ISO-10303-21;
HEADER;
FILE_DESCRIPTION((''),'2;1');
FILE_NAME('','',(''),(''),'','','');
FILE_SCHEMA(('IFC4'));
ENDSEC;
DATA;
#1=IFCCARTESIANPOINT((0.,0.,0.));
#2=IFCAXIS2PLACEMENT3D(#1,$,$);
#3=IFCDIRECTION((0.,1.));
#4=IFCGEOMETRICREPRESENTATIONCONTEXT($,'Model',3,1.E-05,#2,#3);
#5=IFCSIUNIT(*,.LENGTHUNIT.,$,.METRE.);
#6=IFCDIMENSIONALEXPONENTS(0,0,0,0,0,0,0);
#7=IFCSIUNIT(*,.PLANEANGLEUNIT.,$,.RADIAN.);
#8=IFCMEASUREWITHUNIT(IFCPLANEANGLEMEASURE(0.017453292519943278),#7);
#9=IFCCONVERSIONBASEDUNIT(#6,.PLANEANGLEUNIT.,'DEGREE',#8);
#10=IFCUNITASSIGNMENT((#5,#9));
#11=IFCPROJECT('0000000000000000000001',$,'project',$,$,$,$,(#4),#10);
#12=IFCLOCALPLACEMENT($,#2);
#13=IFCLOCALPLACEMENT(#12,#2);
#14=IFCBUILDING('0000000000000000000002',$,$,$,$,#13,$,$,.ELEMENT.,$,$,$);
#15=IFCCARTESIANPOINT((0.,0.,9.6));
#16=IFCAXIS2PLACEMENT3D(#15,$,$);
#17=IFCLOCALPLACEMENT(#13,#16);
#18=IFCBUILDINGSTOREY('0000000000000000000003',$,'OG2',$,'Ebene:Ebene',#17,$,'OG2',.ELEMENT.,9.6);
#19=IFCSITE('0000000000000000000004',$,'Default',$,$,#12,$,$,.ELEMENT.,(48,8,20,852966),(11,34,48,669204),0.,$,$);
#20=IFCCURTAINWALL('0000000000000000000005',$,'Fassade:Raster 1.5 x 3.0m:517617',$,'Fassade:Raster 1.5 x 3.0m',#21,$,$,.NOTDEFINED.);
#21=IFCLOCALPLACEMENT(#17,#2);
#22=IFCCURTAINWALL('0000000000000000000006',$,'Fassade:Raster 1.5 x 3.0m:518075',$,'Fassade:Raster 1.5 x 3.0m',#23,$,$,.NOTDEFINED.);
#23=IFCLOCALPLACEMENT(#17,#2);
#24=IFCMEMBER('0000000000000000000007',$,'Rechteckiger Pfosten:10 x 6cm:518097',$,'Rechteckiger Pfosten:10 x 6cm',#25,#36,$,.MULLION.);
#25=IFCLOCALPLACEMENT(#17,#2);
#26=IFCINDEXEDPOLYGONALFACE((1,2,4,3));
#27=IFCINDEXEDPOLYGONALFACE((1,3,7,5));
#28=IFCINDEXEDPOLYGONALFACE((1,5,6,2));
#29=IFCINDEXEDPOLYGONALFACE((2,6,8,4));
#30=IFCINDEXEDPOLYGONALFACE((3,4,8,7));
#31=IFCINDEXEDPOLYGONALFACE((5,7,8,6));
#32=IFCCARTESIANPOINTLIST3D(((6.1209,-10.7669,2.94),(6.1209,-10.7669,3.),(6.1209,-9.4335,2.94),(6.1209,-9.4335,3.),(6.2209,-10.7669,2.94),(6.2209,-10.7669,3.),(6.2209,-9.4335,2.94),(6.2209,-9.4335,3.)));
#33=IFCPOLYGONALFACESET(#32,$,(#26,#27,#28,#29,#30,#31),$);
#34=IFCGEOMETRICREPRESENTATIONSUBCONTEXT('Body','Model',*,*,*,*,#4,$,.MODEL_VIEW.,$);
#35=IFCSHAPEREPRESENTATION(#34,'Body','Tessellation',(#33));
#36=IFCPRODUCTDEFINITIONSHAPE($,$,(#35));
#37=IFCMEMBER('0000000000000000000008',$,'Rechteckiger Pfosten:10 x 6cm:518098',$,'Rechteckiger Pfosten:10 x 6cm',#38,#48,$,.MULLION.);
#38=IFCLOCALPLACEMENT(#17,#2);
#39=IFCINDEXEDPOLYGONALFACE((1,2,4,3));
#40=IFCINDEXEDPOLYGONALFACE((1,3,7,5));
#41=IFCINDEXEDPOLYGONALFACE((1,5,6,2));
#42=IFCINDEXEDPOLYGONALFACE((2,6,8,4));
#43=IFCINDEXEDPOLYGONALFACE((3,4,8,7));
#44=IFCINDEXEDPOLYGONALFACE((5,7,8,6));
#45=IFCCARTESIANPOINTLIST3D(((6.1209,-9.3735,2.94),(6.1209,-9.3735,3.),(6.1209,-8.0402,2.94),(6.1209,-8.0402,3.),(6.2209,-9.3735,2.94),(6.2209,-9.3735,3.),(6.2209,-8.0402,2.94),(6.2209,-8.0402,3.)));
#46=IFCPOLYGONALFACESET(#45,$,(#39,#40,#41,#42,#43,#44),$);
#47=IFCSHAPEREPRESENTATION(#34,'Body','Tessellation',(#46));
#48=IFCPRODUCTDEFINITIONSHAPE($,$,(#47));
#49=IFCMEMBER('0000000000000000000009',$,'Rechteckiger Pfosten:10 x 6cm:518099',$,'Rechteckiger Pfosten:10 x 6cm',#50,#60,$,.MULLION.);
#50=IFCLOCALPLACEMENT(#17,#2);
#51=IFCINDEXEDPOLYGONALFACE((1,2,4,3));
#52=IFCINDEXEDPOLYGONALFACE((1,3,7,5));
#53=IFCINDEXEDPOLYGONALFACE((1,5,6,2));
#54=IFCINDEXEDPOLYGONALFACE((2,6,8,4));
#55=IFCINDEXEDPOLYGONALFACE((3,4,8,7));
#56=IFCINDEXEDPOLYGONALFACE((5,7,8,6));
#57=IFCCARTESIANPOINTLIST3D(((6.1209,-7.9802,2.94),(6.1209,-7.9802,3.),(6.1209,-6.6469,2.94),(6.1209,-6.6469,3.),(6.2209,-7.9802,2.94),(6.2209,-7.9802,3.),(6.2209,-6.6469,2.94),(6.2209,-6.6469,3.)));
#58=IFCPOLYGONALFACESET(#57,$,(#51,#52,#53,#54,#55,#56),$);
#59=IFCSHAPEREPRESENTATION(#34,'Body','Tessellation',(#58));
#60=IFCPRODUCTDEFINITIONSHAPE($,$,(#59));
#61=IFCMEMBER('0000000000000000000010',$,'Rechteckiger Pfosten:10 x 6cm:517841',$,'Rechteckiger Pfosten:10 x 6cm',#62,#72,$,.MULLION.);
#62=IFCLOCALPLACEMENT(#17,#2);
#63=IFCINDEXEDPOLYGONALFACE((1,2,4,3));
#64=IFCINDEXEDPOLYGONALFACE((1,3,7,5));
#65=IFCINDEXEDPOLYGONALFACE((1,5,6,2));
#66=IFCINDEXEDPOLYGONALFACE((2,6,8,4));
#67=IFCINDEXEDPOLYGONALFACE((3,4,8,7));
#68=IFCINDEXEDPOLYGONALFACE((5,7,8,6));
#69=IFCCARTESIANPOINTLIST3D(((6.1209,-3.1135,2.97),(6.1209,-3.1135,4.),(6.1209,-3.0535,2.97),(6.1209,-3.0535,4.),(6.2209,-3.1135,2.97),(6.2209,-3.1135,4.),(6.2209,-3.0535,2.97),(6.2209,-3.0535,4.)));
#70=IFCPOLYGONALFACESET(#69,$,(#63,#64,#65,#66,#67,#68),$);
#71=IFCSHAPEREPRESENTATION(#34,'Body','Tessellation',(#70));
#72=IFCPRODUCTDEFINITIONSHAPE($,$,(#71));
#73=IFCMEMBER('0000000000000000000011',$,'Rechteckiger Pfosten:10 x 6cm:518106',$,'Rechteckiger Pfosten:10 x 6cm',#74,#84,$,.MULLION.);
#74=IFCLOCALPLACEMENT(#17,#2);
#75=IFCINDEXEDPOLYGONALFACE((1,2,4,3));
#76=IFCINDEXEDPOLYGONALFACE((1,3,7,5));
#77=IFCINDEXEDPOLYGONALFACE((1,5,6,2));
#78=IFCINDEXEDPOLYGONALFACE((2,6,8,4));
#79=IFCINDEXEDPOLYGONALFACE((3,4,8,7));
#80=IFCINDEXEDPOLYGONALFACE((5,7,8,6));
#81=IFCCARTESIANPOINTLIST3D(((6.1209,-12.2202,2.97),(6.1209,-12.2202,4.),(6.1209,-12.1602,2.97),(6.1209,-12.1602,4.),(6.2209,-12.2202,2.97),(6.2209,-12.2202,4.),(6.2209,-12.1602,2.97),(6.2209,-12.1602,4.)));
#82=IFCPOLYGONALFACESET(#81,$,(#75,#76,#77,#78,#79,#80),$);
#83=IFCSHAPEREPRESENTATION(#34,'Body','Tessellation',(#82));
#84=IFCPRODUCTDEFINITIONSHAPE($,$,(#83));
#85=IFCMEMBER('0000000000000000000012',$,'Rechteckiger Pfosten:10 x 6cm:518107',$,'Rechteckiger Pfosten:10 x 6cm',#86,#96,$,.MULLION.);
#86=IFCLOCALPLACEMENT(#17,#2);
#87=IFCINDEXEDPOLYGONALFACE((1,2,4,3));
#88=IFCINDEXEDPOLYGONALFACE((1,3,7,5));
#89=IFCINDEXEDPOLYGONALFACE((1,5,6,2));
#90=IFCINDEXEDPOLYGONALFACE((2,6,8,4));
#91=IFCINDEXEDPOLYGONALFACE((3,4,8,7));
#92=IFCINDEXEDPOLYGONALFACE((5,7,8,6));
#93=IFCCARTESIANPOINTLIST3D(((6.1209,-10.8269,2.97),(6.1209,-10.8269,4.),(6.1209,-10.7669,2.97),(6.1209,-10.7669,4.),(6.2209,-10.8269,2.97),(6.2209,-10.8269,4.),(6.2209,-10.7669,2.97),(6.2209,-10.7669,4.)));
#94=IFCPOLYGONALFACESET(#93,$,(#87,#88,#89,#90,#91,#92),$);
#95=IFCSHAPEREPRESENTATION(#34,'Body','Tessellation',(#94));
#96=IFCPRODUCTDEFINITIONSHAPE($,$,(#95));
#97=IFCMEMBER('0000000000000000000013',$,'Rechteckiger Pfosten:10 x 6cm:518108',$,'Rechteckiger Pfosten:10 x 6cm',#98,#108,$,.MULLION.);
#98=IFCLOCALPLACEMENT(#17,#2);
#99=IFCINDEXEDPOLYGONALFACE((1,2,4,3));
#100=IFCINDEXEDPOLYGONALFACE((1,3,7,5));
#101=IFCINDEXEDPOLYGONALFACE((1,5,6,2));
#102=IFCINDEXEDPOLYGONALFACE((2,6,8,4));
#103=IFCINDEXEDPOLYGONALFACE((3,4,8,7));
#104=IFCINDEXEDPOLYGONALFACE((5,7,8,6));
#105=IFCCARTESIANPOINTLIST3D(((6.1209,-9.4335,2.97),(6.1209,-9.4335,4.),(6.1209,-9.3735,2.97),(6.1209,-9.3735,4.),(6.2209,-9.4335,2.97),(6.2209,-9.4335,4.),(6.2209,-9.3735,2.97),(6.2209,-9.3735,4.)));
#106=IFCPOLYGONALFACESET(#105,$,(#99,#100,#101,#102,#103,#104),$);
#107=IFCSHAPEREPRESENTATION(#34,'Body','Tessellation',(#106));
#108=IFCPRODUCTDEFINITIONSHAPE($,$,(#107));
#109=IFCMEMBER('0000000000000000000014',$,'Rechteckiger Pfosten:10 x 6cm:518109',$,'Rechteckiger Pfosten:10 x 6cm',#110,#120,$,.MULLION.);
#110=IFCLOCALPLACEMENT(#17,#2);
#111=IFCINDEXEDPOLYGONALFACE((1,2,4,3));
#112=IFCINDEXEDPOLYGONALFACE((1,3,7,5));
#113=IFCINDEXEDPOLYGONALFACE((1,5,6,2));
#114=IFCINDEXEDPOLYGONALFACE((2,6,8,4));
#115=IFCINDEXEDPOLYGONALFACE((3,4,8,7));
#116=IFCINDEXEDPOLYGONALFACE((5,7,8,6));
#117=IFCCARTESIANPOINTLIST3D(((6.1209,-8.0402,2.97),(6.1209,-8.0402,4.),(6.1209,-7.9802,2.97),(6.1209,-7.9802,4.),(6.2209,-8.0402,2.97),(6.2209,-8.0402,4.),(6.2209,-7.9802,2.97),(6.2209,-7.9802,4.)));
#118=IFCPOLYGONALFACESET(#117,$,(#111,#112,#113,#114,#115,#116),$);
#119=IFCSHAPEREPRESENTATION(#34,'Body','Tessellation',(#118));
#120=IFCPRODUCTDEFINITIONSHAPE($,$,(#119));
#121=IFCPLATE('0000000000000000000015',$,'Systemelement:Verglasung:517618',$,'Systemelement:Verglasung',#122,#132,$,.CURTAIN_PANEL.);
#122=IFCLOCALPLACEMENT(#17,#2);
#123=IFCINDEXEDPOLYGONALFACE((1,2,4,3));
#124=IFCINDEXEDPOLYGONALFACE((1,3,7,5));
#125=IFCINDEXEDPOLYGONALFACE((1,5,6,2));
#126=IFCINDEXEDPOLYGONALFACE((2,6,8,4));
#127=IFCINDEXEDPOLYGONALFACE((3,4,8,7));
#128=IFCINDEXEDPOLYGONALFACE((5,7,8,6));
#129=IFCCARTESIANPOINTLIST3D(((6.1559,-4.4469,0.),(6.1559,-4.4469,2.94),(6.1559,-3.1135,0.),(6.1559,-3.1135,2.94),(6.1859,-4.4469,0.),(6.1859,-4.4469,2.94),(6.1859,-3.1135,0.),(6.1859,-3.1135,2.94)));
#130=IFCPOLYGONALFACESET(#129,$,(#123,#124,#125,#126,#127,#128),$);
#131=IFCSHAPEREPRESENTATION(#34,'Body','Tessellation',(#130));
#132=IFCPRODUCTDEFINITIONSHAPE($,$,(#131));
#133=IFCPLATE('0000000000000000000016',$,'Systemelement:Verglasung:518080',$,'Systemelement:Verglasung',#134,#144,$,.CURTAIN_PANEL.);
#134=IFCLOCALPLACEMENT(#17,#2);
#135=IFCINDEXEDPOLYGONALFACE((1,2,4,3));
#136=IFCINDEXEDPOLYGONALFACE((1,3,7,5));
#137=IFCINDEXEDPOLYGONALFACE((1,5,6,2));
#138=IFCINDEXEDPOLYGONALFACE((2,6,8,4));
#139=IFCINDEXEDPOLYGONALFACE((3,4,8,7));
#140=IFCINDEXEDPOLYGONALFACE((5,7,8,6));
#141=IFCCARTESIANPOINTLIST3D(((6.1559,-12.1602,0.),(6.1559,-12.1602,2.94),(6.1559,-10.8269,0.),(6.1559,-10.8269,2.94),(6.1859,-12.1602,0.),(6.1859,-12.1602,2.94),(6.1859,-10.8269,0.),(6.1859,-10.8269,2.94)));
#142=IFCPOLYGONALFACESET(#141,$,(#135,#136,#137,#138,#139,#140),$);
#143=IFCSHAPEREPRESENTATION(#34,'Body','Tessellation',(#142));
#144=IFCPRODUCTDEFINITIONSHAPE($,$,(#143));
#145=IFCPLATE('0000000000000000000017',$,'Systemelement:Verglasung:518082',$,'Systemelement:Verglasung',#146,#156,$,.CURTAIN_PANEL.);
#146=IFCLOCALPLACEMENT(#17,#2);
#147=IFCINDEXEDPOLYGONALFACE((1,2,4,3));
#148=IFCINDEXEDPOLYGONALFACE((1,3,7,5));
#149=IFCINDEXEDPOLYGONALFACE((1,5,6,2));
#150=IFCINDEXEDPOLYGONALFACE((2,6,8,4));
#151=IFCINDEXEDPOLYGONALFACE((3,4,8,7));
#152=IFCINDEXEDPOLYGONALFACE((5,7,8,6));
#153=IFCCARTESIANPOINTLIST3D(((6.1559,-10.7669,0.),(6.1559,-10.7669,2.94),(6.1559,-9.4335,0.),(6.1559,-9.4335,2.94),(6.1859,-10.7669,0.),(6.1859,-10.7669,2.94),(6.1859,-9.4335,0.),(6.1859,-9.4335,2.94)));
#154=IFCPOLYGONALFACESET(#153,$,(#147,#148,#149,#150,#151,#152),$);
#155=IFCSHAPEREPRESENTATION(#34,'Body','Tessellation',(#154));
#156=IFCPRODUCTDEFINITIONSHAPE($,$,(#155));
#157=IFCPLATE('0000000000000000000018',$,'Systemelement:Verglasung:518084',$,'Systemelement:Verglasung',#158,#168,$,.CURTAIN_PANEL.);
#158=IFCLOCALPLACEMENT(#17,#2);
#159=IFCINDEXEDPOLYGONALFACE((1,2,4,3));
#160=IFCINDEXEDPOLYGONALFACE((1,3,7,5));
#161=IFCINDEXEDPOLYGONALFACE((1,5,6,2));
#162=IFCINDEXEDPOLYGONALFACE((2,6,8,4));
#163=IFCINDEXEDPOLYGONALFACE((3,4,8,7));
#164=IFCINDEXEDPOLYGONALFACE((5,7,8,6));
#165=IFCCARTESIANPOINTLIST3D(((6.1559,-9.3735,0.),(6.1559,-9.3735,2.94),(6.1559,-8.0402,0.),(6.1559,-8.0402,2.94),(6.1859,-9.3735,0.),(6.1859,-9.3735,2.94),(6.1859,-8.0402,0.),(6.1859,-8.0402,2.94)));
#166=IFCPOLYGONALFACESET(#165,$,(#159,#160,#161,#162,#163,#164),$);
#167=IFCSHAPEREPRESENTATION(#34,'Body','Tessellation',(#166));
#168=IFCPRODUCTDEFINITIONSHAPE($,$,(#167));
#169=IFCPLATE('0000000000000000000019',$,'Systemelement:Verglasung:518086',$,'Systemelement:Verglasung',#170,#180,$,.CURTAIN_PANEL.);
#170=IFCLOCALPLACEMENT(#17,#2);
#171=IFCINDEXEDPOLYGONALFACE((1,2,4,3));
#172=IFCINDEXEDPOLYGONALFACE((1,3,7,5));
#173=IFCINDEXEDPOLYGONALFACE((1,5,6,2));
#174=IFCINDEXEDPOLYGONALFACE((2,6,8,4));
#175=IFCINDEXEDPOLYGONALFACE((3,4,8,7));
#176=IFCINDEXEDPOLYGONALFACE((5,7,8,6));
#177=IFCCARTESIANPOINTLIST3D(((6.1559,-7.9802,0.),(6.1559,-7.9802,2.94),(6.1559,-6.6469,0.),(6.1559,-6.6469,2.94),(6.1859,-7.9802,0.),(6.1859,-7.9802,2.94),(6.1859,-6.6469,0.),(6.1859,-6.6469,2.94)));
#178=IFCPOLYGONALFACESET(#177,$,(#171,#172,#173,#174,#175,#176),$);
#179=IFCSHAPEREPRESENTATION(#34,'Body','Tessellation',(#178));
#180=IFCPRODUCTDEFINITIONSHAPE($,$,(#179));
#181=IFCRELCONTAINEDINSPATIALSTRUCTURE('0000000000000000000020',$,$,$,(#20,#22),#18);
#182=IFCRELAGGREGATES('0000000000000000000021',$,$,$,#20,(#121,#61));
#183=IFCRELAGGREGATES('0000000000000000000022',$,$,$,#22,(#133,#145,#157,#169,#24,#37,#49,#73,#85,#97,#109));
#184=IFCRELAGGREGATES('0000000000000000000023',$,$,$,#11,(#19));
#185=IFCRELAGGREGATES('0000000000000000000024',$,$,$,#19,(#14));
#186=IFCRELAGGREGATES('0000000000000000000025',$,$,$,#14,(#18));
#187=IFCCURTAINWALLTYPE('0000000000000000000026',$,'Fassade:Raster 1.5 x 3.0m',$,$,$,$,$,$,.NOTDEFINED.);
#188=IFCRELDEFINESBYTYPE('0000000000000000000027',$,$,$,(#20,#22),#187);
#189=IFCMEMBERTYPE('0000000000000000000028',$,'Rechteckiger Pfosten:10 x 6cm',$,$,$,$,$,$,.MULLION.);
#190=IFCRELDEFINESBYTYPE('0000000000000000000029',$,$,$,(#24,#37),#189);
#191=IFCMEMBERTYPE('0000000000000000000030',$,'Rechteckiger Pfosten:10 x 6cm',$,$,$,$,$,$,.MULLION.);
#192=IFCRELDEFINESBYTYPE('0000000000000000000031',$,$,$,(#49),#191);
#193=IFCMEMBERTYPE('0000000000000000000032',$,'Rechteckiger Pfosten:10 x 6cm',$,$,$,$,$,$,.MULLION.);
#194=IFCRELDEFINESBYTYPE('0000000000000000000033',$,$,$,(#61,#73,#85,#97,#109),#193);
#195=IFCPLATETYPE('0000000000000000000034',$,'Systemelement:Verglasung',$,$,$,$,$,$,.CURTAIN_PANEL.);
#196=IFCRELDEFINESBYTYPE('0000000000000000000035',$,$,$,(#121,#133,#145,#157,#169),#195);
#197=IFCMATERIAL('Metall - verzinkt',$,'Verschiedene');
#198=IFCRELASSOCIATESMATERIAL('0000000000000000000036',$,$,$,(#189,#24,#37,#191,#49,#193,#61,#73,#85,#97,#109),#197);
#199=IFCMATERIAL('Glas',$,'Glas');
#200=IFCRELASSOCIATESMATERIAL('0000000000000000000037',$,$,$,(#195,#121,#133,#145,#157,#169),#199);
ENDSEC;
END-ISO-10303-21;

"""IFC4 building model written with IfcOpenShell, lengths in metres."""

from ifc_helpers import new_model, entity, si_unit, converted_unit, direction, frame, origin, place, context, subcontext, project, spatial, indexed_curve, outline, extrude, source, transform, mapped, material, type_object, type_shapes, element, aggregate, save


model = new_model("IFC4")

# Units and contexts
model_context = context("Model", 3, precision=1e-05, world=origin(), true_north=direction((0.0, 1.0)))
body_context = subcontext(model_context, "Body", "Model", "MODEL_VIEW")
ifc_project = project(units=[si_unit("LENGTHUNIT", "METRE"), converted_unit("PLANEANGLEUNIT", "DEGREE", entity("IfcPlaneAngleMeasure", 0.017453292519943278), si_unit("PLANEANGLEUNIT", "RADIAN"), dimensions=[0, 0, 0, 0, 0, 0, 0])], contexts=[model_context])

# Site, building, storey
site_placement = place(None, origin())
site = spatial("IfcSite", under=ifc_project, at=site_placement, Name="Default", CompositionType="ELEMENT", RefLatitude=(48, 8, 20, 852966), RefLongitude=(11, 34, 48, 669204), RefElevation=0.0)
building_placement = place(site_placement, origin())
building = spatial("IfcBuilding", under=site, at=building_placement, CompositionType="ELEMENT")
storey_placement = place(building_placement, frame((0.0, 0.0, 9.6)))
storey = spatial("IfcBuildingStorey", under=building, at=storey_placement, Name="OG2", ObjectType="Ebene:Ebene", LongName="OG2", CompositionType="ELEMENT", Elevation=9.6)

# Curtain wall
curtain_wall_type = type_object("IfcCurtainWallType", Name="Fassade:Raster 1.5 x 3.0m", PredefinedType="NOTDEFINED")
curtain_wall_1_placement = place(storey_placement, frame((0.0, 0.0, -9.6)))
curtain_wall_1 = element("IfcCurtainWall", 1, at=curtain_wall_1_placement, inside=storey, type_object=curtain_wall_type, Name="Fassade:Raster 1.5 x 3.0m:517617", ObjectType="Fassade:Raster 1.5 x 3.0m", PredefinedType="NOTDEFINED")
ifc_material_1 = material(Name="Metall - verzinkt", Category="Verschiedene")

# Curtain wall
curtain_wall_2_placement = place(storey_placement, frame((0.0, 0.0, -9.6)))
curtain_wall_2 = element("IfcCurtainWall", 2, at=curtain_wall_2_placement, inside=storey, type_object=curtain_wall_type, Name="Fassade:Raster 1.5 x 3.0m:518075", ObjectType="Fassade:Raster 1.5 x 3.0m", PredefinedType="NOTDEFINED")

# Members
member_type_1 = type_object("IfcMemberType", Name="Rechteckiger Pfosten:10 x 6cm", PredefinedType="MULLION", material=ifc_material_1)
shared_shape_1 = source(origin(), body_context, "Body", "SweptSolid", [
    extrude(outline(indexed_curve([(-0.03, -0.05), (0.03, -0.05), (0.03, 0.05), (-0.03, 0.05), (-0.03, -0.05)], self_intersect=False)), frame((0.0, 0.0, -1.3333), z_axis=(0.0, 0.0, 1.0), x_axis=(-1.0, 0.0, 0.0)), (0.0, 0.0, 1.0), 1.3333),
])
type_shapes(member_type_1, [shared_shape_1])
member_1_placement = place(curtain_wall_2_placement, frame((6.1709, -9.4335, 12.57), z_axis=(0.0, 1.0, 0.0), x_axis=(0.0, 0.0, 1.0)))
member_1 = element("IfcMember", 3, at=member_1_placement, type_object=member_type_1, material=ifc_material_1, Name="Rechteckiger Pfosten:10 x 6cm:518097", ObjectType="Rechteckiger Pfosten:10 x 6cm", PredefinedType="MULLION", context=body_context, shape_type="MappedRepresentation", body=[
    mapped(shared_shape_1, transform((0.0, 0.0, 0.0), scale=1.0)),
])
member_2_placement = place(curtain_wall_2_placement, frame((6.1709, -8.0402, 12.57), z_axis=(0.0, 1.0, 0.0), x_axis=(0.0, 0.0, 1.0)))
member_2 = element("IfcMember", 4, at=member_2_placement, type_object=member_type_1, material=ifc_material_1, Name="Rechteckiger Pfosten:10 x 6cm:518098", ObjectType="Rechteckiger Pfosten:10 x 6cm", PredefinedType="MULLION", context=body_context, shape_type="MappedRepresentation", body=[
    mapped(shared_shape_1, transform((0.0, 0.0, 0.0), scale=1.0)),
])
member_type_2 = type_object("IfcMemberType", Name="Rechteckiger Pfosten:10 x 6cm", PredefinedType="MULLION", material=ifc_material_1)
shared_shape_2 = source(origin(), body_context, "Body", "SweptSolid", [
    extrude(outline(indexed_curve([(-0.03, -0.05), (0.03, -0.05), (0.03, 0.05), (-0.03, 0.05), (-0.03, -0.05)], self_intersect=False)), frame((0.0, 0.0, -1.3333), z_axis=(0.0, 0.0, 1.0), x_axis=(-1.0, 0.0, 0.0)), (0.0, 0.0, 1.0), 1.3333),
])
type_shapes(member_type_2, [shared_shape_2])
member_3_placement = place(curtain_wall_2_placement, frame((6.1709, -6.6469, 12.57), z_axis=(0.0, 1.0, 0.0), x_axis=(0.0, 0.0, 1.0)))
member_3 = element("IfcMember", 5, at=member_3_placement, type_object=member_type_2, material=ifc_material_1, Name="Rechteckiger Pfosten:10 x 6cm:518099", ObjectType="Rechteckiger Pfosten:10 x 6cm", PredefinedType="MULLION", context=body_context, shape_type="MappedRepresentation", body=[
    mapped(shared_shape_2, transform((0.0, 0.0, 0.0), scale=1.0)),
])
member_type_3 = type_object("IfcMemberType", Name="Rechteckiger Pfosten:10 x 6cm", PredefinedType="MULLION", material=ifc_material_1)
shared_shape_3 = source(origin(), body_context, "Body", "SweptSolid", [
    extrude(outline(indexed_curve([(-0.03, -0.05), (0.03, -0.05), (0.03, 0.05), (-0.03, 0.05), (-0.03, -0.05)], self_intersect=False)), frame((0.0, 0.0, -1.03), z_axis=(0.0, 0.0, 1.0), x_axis=(-1.0, 0.0, 0.0)), (0.0, 0.0, 1.0), 1.03),
])
type_shapes(member_type_3, [shared_shape_3])
member_4_placement = place(curtain_wall_1_placement, frame((6.1709, -3.0835, 12.57), z_axis=(0.0, 0.0, -1.0), x_axis=(0.0, 1.0, 0.0)))
member_4 = element("IfcMember", 6, at=member_4_placement, type_object=member_type_3, material=ifc_material_1, Name="Rechteckiger Pfosten:10 x 6cm:517841", ObjectType="Rechteckiger Pfosten:10 x 6cm", PredefinedType="MULLION", context=body_context, shape_type="MappedRepresentation", body=[
    mapped(shared_shape_3, transform((0.0, 0.0, 0.0), scale=1.0)),
])
member_5_placement = place(curtain_wall_2_placement, frame((6.1709, -12.1902, 12.57), z_axis=(0.0, 0.0, -1.0), x_axis=(0.0, 1.0, 0.0)))
member_5 = element("IfcMember", 7, at=member_5_placement, type_object=member_type_3, material=ifc_material_1, Name="Rechteckiger Pfosten:10 x 6cm:518106", ObjectType="Rechteckiger Pfosten:10 x 6cm", PredefinedType="MULLION", context=body_context, shape_type="MappedRepresentation", body=[
    mapped(shared_shape_3, transform((0.0, 0.0, 0.0), scale=1.0)),
])
member_6_placement = place(curtain_wall_2_placement, frame((6.1709, -10.7969, 12.57), z_axis=(0.0, 0.0, -1.0), x_axis=(0.0, 1.0, 0.0)))
member_6 = element("IfcMember", 8, at=member_6_placement, type_object=member_type_3, material=ifc_material_1, Name="Rechteckiger Pfosten:10 x 6cm:518107", ObjectType="Rechteckiger Pfosten:10 x 6cm", PredefinedType="MULLION", context=body_context, shape_type="MappedRepresentation", body=[
    mapped(shared_shape_3, transform((0.0, 0.0, 0.0), scale=1.0)),
])
member_7_placement = place(curtain_wall_2_placement, frame((6.1709, -9.4035, 12.57), z_axis=(0.0, 0.0, -1.0), x_axis=(0.0, 1.0, 0.0)))
member_7 = element("IfcMember", 9, at=member_7_placement, type_object=member_type_3, material=ifc_material_1, Name="Rechteckiger Pfosten:10 x 6cm:518108", ObjectType="Rechteckiger Pfosten:10 x 6cm", PredefinedType="MULLION", context=body_context, shape_type="MappedRepresentation", body=[
    mapped(shared_shape_3, transform((0.0, 0.0, 0.0), scale=1.0)),
])
member_8_placement = place(curtain_wall_2_placement, frame((6.1709, -8.0102, 12.57), z_axis=(0.0, 0.0, -1.0), x_axis=(0.0, 1.0, 0.0)))
member_8 = element("IfcMember", 10, at=member_8_placement, type_object=member_type_3, material=ifc_material_1, Name="Rechteckiger Pfosten:10 x 6cm:518109", ObjectType="Rechteckiger Pfosten:10 x 6cm", PredefinedType="MULLION", context=body_context, shape_type="MappedRepresentation", body=[
    mapped(shared_shape_3, transform((0.0, 0.0, 0.0), scale=1.0)),
])

# Plates
ifc_material_2 = material(Name="Glas", Category="Glas")
plate_type_1 = type_object("IfcPlateType", Name="Systemelement:Verglasung", PredefinedType="CURTAIN_PANEL", material=ifc_material_2)
shared_shape_4 = source(origin(), body_context, "Body", "SweptSolid", [
    extrude(outline(indexed_curve([(-0.015, -0.6667), (0.015, -0.6667), (0.015, 0.6667), (-0.015, 0.6667), (-0.015, -0.6667)], self_intersect=False)), frame((0.0, 0.0, 0.0), z_axis=(0.0, 0.0, 1.0), x_axis=(0.0, 1.0, 0.0)), (0.0, 0.0, 1.0), 2.94),
])
type_shapes(plate_type_1, [shared_shape_4])
plate_1_placement = place(curtain_wall_1_placement, frame((6.1709, -3.7802, 9.6), z_axis=(0.0, 0.0, 1.0), x_axis=(0.0, 1.0, 0.0)))
plate_1 = element("IfcPlate", 11, at=plate_1_placement, type_object=plate_type_1, material=ifc_material_2, Name="Systemelement:Verglasung:517618", ObjectType="Systemelement:Verglasung", PredefinedType="CURTAIN_PANEL", context=body_context, shape_type="MappedRepresentation", body=[
    mapped(shared_shape_4, transform((0.0, 0.0, 0.0), scale=1.0)),
])
plate_2_placement = place(curtain_wall_2_placement, frame((6.1709, -11.4935, 9.6), z_axis=(0.0, 0.0, 1.0), x_axis=(0.0, 1.0, 0.0)))
plate_2 = element("IfcPlate", 12, at=plate_2_placement, type_object=plate_type_1, material=ifc_material_2, Name="Systemelement:Verglasung:518080", ObjectType="Systemelement:Verglasung", PredefinedType="CURTAIN_PANEL", context=body_context, shape_type="MappedRepresentation", body=[
    mapped(shared_shape_4, transform((0.0, 0.0, 0.0), scale=1.0)),
])
plate_3_placement = place(curtain_wall_2_placement, frame((6.1709, -10.1002, 9.6), z_axis=(0.0, 0.0, 1.0), x_axis=(0.0, 1.0, 0.0)))
plate_3 = element("IfcPlate", 13, at=plate_3_placement, type_object=plate_type_1, material=ifc_material_2, Name="Systemelement:Verglasung:518082", ObjectType="Systemelement:Verglasung", PredefinedType="CURTAIN_PANEL", context=body_context, shape_type="MappedRepresentation", body=[
    mapped(shared_shape_4, transform((0.0, 0.0, 0.0), scale=1.0)),
])
plate_4_placement = place(curtain_wall_2_placement, frame((6.1709, -8.7069, 9.6), z_axis=(0.0, 0.0, 1.0), x_axis=(0.0, 1.0, 0.0)))
plate_4 = element("IfcPlate", 14, at=plate_4_placement, type_object=plate_type_1, material=ifc_material_2, Name="Systemelement:Verglasung:518084", ObjectType="Systemelement:Verglasung", PredefinedType="CURTAIN_PANEL", context=body_context, shape_type="MappedRepresentation", body=[
    mapped(shared_shape_4, transform((0.0, 0.0, 0.0), scale=1.0)),
])
plate_5_placement = place(curtain_wall_2_placement, frame((6.1709, -7.3135, 9.6), z_axis=(0.0, 0.0, 1.0), x_axis=(0.0, 1.0, 0.0)))
plate_5 = element("IfcPlate", 15, at=plate_5_placement, type_object=plate_type_1, material=ifc_material_2, Name="Systemelement:Verglasung:518086", ObjectType="Systemelement:Verglasung", PredefinedType="CURTAIN_PANEL", context=body_context, shape_type="MappedRepresentation", body=[
    mapped(shared_shape_4, transform((0.0, 0.0, 0.0), scale=1.0)),
])
aggregate(curtain_wall_1, [plate_1, member_4])
aggregate(curtain_wall_2, [plate_2, plate_3, plate_4, plate_5, member_1, member_2, member_3, member_5, member_6, member_7, member_8])

save(model, "model.ifc")
